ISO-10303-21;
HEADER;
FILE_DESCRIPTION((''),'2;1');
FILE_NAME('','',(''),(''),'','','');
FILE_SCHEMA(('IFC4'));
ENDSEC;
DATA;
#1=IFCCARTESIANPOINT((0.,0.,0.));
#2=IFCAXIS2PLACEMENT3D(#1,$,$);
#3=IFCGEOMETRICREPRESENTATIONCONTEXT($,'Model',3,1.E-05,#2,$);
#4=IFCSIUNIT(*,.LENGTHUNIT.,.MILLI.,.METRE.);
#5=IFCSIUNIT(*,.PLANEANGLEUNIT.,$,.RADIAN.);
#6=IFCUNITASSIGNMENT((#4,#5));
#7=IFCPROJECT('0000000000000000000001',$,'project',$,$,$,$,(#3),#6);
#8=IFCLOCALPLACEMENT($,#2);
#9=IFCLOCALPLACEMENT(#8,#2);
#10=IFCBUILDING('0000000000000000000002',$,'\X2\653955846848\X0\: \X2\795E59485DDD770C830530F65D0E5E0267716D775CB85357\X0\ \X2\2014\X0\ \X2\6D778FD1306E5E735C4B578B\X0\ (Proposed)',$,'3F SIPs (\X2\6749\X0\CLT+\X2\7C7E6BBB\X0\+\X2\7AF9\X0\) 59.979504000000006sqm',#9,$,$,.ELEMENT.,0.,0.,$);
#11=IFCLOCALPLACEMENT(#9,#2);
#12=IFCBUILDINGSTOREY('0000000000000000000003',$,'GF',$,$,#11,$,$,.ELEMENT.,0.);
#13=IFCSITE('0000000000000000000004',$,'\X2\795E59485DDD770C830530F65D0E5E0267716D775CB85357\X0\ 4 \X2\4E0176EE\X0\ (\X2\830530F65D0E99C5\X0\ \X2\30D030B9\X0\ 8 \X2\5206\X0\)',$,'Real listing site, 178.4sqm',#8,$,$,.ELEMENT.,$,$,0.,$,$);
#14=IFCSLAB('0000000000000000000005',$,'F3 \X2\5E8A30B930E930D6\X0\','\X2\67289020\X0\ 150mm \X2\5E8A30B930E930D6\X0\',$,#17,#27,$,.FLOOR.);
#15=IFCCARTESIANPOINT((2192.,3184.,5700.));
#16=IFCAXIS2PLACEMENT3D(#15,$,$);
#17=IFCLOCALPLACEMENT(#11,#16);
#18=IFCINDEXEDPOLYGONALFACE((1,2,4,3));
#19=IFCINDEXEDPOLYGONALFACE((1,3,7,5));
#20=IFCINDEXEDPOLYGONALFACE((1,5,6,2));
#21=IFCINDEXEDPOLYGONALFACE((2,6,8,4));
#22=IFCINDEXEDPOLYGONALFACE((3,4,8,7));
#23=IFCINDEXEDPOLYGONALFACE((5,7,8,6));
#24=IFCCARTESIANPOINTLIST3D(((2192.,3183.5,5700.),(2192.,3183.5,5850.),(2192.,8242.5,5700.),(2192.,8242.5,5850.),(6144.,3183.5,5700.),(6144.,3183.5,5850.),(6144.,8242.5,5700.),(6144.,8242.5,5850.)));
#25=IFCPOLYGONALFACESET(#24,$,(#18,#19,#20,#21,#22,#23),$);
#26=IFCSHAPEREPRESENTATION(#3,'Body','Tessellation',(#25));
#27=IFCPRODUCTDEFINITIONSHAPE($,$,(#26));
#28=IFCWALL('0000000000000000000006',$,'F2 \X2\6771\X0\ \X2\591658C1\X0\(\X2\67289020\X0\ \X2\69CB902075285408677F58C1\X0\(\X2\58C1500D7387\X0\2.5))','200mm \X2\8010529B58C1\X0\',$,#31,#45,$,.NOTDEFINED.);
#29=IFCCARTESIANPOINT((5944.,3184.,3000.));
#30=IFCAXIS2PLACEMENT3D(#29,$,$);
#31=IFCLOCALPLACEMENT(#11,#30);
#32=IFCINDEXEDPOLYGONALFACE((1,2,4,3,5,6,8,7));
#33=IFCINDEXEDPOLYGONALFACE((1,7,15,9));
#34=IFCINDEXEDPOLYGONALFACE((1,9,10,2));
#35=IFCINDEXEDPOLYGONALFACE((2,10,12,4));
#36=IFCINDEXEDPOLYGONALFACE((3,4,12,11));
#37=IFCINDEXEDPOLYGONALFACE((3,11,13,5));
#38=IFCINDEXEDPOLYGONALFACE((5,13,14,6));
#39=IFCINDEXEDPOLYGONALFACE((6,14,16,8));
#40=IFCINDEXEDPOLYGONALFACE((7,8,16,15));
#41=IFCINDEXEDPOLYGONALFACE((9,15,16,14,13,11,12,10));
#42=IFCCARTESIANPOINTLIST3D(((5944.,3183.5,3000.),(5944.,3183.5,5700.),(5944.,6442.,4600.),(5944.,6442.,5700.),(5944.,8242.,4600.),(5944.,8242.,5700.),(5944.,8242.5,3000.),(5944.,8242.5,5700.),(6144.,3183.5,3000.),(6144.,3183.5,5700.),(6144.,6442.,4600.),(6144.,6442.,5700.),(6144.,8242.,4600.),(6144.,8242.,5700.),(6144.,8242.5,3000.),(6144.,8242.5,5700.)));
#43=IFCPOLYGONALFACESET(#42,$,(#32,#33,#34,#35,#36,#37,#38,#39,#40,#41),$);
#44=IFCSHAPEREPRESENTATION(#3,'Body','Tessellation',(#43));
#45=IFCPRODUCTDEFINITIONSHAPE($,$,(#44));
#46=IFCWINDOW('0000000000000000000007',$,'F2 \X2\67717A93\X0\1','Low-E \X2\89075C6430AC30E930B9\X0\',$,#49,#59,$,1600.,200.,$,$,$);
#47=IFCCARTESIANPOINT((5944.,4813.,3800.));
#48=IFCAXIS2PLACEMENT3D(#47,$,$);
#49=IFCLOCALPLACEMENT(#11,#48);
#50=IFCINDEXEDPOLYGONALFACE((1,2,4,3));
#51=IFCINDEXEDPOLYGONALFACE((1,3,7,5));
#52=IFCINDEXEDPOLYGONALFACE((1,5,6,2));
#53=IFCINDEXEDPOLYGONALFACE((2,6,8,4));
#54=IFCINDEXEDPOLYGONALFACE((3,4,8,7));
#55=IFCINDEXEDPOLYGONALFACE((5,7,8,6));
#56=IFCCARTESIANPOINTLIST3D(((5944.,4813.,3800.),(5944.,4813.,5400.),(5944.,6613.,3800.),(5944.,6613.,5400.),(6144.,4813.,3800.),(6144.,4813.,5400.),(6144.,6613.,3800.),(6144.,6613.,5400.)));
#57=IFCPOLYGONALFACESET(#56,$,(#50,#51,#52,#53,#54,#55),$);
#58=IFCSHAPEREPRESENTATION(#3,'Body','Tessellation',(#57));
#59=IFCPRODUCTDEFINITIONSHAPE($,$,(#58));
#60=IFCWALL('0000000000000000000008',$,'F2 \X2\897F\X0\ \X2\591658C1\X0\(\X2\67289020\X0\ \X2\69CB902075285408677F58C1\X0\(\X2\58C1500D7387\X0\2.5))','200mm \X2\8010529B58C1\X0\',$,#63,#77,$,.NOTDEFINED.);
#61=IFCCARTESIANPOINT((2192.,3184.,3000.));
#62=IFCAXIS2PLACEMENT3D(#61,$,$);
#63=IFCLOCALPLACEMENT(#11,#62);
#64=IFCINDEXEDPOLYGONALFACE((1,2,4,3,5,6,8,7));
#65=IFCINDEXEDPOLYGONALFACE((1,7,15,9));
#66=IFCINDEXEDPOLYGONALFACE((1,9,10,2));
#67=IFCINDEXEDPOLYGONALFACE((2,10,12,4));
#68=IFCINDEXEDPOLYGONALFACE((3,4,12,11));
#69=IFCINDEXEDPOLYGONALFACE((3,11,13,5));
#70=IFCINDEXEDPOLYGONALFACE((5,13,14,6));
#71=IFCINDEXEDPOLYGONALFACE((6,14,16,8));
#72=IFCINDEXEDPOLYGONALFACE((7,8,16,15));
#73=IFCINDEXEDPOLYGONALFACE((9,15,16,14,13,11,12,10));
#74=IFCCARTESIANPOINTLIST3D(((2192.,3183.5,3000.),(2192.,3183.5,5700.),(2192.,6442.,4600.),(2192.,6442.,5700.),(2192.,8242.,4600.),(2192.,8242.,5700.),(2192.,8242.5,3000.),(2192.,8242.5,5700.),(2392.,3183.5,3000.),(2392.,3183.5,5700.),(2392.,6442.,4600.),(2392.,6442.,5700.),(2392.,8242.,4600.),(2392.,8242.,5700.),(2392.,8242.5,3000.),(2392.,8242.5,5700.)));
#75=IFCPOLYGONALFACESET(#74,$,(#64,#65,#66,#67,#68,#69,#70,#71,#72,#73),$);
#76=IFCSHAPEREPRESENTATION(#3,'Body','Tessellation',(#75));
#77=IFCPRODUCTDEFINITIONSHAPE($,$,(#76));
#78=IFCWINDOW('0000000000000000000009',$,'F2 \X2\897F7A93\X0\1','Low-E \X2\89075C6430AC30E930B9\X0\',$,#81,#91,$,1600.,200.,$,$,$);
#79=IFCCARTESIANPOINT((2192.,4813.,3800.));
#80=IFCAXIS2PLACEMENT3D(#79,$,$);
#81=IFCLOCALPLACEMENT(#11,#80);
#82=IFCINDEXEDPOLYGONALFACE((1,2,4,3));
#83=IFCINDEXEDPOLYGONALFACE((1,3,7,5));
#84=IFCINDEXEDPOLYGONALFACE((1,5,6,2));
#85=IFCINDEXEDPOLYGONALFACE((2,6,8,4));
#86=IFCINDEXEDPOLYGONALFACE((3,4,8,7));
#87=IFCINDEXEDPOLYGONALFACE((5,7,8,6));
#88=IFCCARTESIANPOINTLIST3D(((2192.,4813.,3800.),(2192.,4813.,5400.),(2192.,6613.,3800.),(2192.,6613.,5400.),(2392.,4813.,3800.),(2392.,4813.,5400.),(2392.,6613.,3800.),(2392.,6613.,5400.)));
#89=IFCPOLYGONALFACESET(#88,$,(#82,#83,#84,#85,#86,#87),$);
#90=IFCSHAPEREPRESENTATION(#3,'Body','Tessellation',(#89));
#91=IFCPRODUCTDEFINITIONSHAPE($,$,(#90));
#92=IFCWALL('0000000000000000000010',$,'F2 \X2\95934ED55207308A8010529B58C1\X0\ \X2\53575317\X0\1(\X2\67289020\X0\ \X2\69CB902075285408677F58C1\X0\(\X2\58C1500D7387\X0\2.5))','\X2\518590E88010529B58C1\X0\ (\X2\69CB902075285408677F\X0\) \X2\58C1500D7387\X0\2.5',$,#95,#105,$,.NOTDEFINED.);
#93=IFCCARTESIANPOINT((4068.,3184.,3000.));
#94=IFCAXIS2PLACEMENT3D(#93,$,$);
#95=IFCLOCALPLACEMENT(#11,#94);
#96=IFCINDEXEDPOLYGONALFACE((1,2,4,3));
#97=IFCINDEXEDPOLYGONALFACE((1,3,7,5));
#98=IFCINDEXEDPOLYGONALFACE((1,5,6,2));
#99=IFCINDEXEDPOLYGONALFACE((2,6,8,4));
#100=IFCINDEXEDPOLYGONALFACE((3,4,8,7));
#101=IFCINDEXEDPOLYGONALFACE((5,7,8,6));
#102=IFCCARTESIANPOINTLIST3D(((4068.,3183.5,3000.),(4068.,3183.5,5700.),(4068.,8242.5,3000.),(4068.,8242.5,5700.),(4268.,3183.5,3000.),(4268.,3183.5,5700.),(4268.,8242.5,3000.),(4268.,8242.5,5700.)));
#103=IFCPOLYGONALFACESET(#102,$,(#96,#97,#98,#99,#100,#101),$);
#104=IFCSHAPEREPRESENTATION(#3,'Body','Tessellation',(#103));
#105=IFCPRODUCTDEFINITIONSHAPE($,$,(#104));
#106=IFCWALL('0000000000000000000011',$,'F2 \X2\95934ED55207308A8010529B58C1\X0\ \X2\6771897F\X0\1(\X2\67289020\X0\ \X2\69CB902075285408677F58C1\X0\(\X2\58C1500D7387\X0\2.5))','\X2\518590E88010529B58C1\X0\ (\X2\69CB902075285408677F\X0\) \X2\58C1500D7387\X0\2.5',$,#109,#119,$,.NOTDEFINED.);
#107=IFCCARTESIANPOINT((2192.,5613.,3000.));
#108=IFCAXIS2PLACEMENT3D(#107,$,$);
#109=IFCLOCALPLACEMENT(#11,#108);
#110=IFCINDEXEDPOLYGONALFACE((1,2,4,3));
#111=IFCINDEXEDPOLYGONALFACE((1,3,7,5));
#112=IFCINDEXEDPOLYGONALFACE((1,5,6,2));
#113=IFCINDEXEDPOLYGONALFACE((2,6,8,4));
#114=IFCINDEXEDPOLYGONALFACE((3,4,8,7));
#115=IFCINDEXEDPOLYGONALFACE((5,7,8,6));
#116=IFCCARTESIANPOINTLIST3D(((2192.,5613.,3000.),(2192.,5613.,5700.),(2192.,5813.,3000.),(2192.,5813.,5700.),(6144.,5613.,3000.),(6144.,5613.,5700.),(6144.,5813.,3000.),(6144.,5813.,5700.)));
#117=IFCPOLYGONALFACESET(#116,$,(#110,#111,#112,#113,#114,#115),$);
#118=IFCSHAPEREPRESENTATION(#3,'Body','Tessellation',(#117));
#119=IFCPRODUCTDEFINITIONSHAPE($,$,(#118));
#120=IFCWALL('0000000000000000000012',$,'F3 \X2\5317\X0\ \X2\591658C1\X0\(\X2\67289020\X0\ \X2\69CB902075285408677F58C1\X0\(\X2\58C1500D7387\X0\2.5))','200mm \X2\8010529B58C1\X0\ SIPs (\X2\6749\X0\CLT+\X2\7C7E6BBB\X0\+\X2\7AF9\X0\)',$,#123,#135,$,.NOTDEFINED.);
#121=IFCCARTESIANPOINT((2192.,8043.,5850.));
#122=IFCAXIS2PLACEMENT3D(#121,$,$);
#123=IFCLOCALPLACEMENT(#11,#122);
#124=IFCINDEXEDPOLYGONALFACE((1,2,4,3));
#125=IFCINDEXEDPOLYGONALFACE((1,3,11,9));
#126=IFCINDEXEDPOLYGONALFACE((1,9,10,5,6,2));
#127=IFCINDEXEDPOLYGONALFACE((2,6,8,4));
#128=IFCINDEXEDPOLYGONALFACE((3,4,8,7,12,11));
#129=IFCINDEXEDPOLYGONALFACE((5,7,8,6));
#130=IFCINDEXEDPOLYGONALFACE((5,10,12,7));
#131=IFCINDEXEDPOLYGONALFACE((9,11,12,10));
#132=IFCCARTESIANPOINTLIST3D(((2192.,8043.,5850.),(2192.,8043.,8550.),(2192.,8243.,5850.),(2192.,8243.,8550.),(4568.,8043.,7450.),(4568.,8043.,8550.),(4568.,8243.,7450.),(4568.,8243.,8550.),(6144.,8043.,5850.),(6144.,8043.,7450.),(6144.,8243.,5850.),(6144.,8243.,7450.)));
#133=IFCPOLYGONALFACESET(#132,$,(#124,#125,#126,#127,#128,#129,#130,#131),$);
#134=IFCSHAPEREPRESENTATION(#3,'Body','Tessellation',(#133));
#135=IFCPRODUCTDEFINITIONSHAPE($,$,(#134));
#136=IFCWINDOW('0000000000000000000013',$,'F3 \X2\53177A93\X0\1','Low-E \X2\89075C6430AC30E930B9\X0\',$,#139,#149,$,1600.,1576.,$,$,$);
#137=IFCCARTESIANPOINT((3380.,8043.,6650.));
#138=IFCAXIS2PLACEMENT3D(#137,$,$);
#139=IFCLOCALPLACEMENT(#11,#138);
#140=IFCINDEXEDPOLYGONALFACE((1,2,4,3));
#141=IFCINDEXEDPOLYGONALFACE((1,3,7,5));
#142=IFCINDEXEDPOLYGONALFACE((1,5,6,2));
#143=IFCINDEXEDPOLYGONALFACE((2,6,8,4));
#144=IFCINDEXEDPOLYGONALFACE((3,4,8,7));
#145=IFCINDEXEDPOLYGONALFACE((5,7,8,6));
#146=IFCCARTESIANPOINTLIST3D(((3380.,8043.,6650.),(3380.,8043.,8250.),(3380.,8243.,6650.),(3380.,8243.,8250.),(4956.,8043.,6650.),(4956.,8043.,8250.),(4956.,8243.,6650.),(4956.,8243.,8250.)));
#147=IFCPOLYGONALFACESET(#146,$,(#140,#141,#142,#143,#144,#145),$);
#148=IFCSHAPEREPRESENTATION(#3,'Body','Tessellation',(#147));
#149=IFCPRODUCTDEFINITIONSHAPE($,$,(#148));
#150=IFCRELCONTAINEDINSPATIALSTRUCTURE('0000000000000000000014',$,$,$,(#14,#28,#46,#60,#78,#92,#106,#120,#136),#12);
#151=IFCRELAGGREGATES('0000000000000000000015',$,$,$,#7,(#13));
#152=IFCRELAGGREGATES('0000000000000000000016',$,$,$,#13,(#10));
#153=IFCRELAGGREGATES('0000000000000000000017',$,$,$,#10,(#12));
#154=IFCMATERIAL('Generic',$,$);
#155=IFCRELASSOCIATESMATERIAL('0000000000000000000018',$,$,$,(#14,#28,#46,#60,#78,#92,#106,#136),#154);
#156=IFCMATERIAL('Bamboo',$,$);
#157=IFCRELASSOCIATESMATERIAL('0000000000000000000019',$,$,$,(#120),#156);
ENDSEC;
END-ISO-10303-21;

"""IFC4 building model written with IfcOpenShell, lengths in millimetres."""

from ifc_helpers import new_model, si_unit, frame, frame_2d, origin, place, context, project, spatial, rectangle, extrude, material, element, fill, save


model = new_model("IFC4")

# Units and contexts
model_context = context("Model", 3, precision=1e-05, world=origin())
ifc_project = project(units=[si_unit("LENGTHUNIT", "METRE", prefix="MILLI"), si_unit("PLANEANGLEUNIT", "RADIAN")], contexts=[model_context])

# Site, building, storey
site_placement = place(None, origin())
site = spatial("IfcSite", under=ifc_project, at=site_placement, Name="神奈川県茅ヶ崎市東海岸南 4 丁目 (茅ヶ崎駅 バス 8 分)", ObjectType="Real listing site, 178.4sqm", CompositionType="ELEMENT", RefElevation=0.0)
building_placement = place(site_placement, origin())
building = spatial("IfcBuilding", under=site, at=building_placement, Name="改善案: 神奈川県茅ヶ崎市東海岸南 — 海近の平屋型 (Proposed)", ObjectType="3F SIPs (杉CLT+籾殻+竹) 59.979504000000006sqm", CompositionType="ELEMENT", ElevationOfRefHeight=0.0, ElevationOfTerrain=0.0)
storey_placement = place(building_placement, origin())
storey = spatial("IfcBuildingStorey", under=building, at=storey_placement, Name="GF", CompositionType="ELEMENT", Elevation=0.0)

# Slab
ifc_material_1 = material(Name="Generic")
slab_placement = place(storey_placement, frame((2192.0, 3184.0, 5700.0)))
element("IfcSlab", 1, at=slab_placement, inside=storey, material=ifc_material_1, Name="F3 床スラブ", Description="木造 150mm 床スラブ", PredefinedType="FLOOR", context=model_context, shape_type="SweptSolid", body=[
    extrude(rectangle(XDim=3952.0, YDim=5059.0, at=frame_2d((1976.0, 2529.0))), frame((2192.0, 3184.0, 5700.0)), (0.0, 0.0, 1.0), 150.0),
])

# Walls, openings, windows
wall_1_placement = place(storey_placement, frame((5944.0, 3184.0, 3000.0)))
wall_1 = element("IfcWall", 2, at=wall_1_placement, inside=storey, material=ifc_material_1, Name="F2 東 外壁(木造 構造用合板壁(壁倍率2.5))", Description="200mm 耐力壁", PredefinedType="NOTDEFINED", context=model_context, shape_type="SweptSolid", body=[
    extrude(rectangle(XDim=200.0, YDim=5059.0, at=frame_2d((100.0, 2529.0))), frame((5944.0, 3184.0, 3000.0)), (0.0, 0.0, 1.0), 2700.0),
])
opening_1_placement = place(storey_placement, frame((5944.0, 4813.0, 3800.0)))
opening_1 = element("IfcOpeningElement", 3, at=opening_1_placement, cuts=wall_1, PredefinedType="NOTDEFINED", context=model_context, shape_type="SweptSolid", body=[
    extrude(rectangle(XDim=200.0, YDim=1800.0, at=frame_2d((100.0, 900.0))), frame((5944.0, 4813.0, 3800.0)), (0.0, 0.0, 1.0), 1600.0),
])
window_1_placement = place(storey_placement, frame((5944.0, 4813.0, 3800.0)))
window_1 = element("IfcWindow", 4, at=window_1_placement, inside=storey, material=ifc_material_1, Name="F2 東窓1", Description="Low-E 複層ガラス", OverallHeight=1600.0, OverallWidth=200.0, context=model_context, shape_type="SweptSolid", body=[
    extrude(rectangle(XDim=200.0, YDim=1800.0, at=frame_2d((100.0, 900.0))), frame((5944.0, 4813.0, 3800.0)), (0.0, 0.0, 1.0), 1600.0),
])
fill(opening_1, window_1)
wall_2_placement = place(storey_placement, frame((2192.0, 3184.0, 3000.0)))
wall_2 = element("IfcWall", 5, at=wall_2_placement, inside=storey, material=ifc_material_1, Name="F2 西 外壁(木造 構造用合板壁(壁倍率2.5))", Description="200mm 耐力壁", PredefinedType="NOTDEFINED", context=model_context, shape_type="SweptSolid", body=[
    extrude(rectangle(XDim=200.0, YDim=5059.0, at=frame_2d((100.0, 2529.0))), frame((2192.0, 3184.0, 3000.0)), (0.0, 0.0, 1.0), 2700.0),
])
opening_2_placement = place(storey_placement, frame((2192.0, 4813.0, 3800.0)))
opening_2 = element("IfcOpeningElement", 6, at=opening_2_placement, cuts=wall_2, PredefinedType="NOTDEFINED", context=model_context, shape_type="SweptSolid", body=[
    extrude(rectangle(XDim=200.0, YDim=1800.0, at=frame_2d((100.0, 900.0))), frame((2192.0, 4813.0, 3800.0)), (0.0, 0.0, 1.0), 1600.0),
])
window_2_placement = place(storey_placement, frame((2192.0, 4813.0, 3800.0)))
window_2 = element("IfcWindow", 7, at=window_2_placement, inside=storey, material=ifc_material_1, Name="F2 西窓1", Description="Low-E 複層ガラス", OverallHeight=1600.0, OverallWidth=200.0, context=model_context, shape_type="SweptSolid", body=[
    extrude(rectangle(XDim=200.0, YDim=1800.0, at=frame_2d((100.0, 900.0))), frame((2192.0, 4813.0, 3800.0)), (0.0, 0.0, 1.0), 1600.0),
])
fill(opening_2, window_2)

# Walls
wall_3_placement = place(storey_placement, frame((4068.0, 3184.0, 3000.0)))
element("IfcWall", 8, at=wall_3_placement, inside=storey, material=ifc_material_1, Name="F2 間仕切り耐力壁 南北1(木造 構造用合板壁(壁倍率2.5))", Description="内部耐力壁 (構造用合板) 壁倍率2.5", PredefinedType="NOTDEFINED", context=model_context, shape_type="SweptSolid", body=[
    extrude(rectangle(XDim=200.0, YDim=5059.0, at=frame_2d((100.0, 2529.0))), frame((4068.0, 3184.0, 3000.0)), (0.0, 0.0, 1.0), 2700.0),
])
wall_4_placement = place(storey_placement, frame((2192.0, 5613.0, 3000.0)))
element("IfcWall", 9, at=wall_4_placement, inside=storey, material=ifc_material_1, Name="F2 間仕切り耐力壁 東西1(木造 構造用合板壁(壁倍率2.5))", Description="内部耐力壁 (構造用合板) 壁倍率2.5", PredefinedType="NOTDEFINED", context=model_context, shape_type="SweptSolid", body=[
    extrude(rectangle(XDim=3952.0, YDim=200.0, at=frame_2d((1976.0, 100.0))), frame((2192.0, 5613.0, 3000.0)), (0.0, 0.0, 1.0), 2700.0),
])

# Wall, opening, window
ifc_material_2 = material(Name="Bamboo")
wall_5_placement = place(storey_placement, frame((2192.0, 8043.0, 5850.0)))
wall_5 = element("IfcWall", 10, at=wall_5_placement, inside=storey, material=ifc_material_2, Name="F3 北 外壁(木造 構造用合板壁(壁倍率2.5))", Description="200mm 耐力壁 SIPs (杉CLT+籾殻+竹)", PredefinedType="NOTDEFINED", context=model_context, shape_type="SweptSolid", body=[
    extrude(rectangle(XDim=3952.0, YDim=200.0, at=frame_2d((1976.0, 100.0))), frame((2192.0, 8043.0, 5850.0)), (0.0, 0.0, 1.0), 2700.0),
])
opening_3_placement = place(storey_placement, frame((3380.0, 8043.0, 6650.0)))
opening_3 = element("IfcOpeningElement", 11, at=opening_3_placement, cuts=wall_5, PredefinedType="NOTDEFINED", context=model_context, shape_type="SweptSolid", body=[
    extrude(rectangle(XDim=1576.0, YDim=200.0, at=frame_2d((788.0, 100.0))), frame((3380.0, 8043.0, 6650.0)), (0.0, 0.0, 1.0), 1600.0),
])
window_3_placement = place(storey_placement, frame((3380.0, 8043.0, 6650.0)))
window_3 = element("IfcWindow", 12, at=window_3_placement, inside=storey, material=ifc_material_1, Name="F3 北窓1", Description="Low-E 複層ガラス", OverallHeight=1600.0, OverallWidth=1576.0, context=model_context, shape_type="SweptSolid", body=[
    extrude(rectangle(XDim=1576.0, YDim=200.0, at=frame_2d((788.0, 100.0))), frame((3380.0, 8043.0, 6650.0)), (0.0, 0.0, 1.0), 1600.0),
])
fill(opening_3, window_3)

save(model, "model.ifc")
